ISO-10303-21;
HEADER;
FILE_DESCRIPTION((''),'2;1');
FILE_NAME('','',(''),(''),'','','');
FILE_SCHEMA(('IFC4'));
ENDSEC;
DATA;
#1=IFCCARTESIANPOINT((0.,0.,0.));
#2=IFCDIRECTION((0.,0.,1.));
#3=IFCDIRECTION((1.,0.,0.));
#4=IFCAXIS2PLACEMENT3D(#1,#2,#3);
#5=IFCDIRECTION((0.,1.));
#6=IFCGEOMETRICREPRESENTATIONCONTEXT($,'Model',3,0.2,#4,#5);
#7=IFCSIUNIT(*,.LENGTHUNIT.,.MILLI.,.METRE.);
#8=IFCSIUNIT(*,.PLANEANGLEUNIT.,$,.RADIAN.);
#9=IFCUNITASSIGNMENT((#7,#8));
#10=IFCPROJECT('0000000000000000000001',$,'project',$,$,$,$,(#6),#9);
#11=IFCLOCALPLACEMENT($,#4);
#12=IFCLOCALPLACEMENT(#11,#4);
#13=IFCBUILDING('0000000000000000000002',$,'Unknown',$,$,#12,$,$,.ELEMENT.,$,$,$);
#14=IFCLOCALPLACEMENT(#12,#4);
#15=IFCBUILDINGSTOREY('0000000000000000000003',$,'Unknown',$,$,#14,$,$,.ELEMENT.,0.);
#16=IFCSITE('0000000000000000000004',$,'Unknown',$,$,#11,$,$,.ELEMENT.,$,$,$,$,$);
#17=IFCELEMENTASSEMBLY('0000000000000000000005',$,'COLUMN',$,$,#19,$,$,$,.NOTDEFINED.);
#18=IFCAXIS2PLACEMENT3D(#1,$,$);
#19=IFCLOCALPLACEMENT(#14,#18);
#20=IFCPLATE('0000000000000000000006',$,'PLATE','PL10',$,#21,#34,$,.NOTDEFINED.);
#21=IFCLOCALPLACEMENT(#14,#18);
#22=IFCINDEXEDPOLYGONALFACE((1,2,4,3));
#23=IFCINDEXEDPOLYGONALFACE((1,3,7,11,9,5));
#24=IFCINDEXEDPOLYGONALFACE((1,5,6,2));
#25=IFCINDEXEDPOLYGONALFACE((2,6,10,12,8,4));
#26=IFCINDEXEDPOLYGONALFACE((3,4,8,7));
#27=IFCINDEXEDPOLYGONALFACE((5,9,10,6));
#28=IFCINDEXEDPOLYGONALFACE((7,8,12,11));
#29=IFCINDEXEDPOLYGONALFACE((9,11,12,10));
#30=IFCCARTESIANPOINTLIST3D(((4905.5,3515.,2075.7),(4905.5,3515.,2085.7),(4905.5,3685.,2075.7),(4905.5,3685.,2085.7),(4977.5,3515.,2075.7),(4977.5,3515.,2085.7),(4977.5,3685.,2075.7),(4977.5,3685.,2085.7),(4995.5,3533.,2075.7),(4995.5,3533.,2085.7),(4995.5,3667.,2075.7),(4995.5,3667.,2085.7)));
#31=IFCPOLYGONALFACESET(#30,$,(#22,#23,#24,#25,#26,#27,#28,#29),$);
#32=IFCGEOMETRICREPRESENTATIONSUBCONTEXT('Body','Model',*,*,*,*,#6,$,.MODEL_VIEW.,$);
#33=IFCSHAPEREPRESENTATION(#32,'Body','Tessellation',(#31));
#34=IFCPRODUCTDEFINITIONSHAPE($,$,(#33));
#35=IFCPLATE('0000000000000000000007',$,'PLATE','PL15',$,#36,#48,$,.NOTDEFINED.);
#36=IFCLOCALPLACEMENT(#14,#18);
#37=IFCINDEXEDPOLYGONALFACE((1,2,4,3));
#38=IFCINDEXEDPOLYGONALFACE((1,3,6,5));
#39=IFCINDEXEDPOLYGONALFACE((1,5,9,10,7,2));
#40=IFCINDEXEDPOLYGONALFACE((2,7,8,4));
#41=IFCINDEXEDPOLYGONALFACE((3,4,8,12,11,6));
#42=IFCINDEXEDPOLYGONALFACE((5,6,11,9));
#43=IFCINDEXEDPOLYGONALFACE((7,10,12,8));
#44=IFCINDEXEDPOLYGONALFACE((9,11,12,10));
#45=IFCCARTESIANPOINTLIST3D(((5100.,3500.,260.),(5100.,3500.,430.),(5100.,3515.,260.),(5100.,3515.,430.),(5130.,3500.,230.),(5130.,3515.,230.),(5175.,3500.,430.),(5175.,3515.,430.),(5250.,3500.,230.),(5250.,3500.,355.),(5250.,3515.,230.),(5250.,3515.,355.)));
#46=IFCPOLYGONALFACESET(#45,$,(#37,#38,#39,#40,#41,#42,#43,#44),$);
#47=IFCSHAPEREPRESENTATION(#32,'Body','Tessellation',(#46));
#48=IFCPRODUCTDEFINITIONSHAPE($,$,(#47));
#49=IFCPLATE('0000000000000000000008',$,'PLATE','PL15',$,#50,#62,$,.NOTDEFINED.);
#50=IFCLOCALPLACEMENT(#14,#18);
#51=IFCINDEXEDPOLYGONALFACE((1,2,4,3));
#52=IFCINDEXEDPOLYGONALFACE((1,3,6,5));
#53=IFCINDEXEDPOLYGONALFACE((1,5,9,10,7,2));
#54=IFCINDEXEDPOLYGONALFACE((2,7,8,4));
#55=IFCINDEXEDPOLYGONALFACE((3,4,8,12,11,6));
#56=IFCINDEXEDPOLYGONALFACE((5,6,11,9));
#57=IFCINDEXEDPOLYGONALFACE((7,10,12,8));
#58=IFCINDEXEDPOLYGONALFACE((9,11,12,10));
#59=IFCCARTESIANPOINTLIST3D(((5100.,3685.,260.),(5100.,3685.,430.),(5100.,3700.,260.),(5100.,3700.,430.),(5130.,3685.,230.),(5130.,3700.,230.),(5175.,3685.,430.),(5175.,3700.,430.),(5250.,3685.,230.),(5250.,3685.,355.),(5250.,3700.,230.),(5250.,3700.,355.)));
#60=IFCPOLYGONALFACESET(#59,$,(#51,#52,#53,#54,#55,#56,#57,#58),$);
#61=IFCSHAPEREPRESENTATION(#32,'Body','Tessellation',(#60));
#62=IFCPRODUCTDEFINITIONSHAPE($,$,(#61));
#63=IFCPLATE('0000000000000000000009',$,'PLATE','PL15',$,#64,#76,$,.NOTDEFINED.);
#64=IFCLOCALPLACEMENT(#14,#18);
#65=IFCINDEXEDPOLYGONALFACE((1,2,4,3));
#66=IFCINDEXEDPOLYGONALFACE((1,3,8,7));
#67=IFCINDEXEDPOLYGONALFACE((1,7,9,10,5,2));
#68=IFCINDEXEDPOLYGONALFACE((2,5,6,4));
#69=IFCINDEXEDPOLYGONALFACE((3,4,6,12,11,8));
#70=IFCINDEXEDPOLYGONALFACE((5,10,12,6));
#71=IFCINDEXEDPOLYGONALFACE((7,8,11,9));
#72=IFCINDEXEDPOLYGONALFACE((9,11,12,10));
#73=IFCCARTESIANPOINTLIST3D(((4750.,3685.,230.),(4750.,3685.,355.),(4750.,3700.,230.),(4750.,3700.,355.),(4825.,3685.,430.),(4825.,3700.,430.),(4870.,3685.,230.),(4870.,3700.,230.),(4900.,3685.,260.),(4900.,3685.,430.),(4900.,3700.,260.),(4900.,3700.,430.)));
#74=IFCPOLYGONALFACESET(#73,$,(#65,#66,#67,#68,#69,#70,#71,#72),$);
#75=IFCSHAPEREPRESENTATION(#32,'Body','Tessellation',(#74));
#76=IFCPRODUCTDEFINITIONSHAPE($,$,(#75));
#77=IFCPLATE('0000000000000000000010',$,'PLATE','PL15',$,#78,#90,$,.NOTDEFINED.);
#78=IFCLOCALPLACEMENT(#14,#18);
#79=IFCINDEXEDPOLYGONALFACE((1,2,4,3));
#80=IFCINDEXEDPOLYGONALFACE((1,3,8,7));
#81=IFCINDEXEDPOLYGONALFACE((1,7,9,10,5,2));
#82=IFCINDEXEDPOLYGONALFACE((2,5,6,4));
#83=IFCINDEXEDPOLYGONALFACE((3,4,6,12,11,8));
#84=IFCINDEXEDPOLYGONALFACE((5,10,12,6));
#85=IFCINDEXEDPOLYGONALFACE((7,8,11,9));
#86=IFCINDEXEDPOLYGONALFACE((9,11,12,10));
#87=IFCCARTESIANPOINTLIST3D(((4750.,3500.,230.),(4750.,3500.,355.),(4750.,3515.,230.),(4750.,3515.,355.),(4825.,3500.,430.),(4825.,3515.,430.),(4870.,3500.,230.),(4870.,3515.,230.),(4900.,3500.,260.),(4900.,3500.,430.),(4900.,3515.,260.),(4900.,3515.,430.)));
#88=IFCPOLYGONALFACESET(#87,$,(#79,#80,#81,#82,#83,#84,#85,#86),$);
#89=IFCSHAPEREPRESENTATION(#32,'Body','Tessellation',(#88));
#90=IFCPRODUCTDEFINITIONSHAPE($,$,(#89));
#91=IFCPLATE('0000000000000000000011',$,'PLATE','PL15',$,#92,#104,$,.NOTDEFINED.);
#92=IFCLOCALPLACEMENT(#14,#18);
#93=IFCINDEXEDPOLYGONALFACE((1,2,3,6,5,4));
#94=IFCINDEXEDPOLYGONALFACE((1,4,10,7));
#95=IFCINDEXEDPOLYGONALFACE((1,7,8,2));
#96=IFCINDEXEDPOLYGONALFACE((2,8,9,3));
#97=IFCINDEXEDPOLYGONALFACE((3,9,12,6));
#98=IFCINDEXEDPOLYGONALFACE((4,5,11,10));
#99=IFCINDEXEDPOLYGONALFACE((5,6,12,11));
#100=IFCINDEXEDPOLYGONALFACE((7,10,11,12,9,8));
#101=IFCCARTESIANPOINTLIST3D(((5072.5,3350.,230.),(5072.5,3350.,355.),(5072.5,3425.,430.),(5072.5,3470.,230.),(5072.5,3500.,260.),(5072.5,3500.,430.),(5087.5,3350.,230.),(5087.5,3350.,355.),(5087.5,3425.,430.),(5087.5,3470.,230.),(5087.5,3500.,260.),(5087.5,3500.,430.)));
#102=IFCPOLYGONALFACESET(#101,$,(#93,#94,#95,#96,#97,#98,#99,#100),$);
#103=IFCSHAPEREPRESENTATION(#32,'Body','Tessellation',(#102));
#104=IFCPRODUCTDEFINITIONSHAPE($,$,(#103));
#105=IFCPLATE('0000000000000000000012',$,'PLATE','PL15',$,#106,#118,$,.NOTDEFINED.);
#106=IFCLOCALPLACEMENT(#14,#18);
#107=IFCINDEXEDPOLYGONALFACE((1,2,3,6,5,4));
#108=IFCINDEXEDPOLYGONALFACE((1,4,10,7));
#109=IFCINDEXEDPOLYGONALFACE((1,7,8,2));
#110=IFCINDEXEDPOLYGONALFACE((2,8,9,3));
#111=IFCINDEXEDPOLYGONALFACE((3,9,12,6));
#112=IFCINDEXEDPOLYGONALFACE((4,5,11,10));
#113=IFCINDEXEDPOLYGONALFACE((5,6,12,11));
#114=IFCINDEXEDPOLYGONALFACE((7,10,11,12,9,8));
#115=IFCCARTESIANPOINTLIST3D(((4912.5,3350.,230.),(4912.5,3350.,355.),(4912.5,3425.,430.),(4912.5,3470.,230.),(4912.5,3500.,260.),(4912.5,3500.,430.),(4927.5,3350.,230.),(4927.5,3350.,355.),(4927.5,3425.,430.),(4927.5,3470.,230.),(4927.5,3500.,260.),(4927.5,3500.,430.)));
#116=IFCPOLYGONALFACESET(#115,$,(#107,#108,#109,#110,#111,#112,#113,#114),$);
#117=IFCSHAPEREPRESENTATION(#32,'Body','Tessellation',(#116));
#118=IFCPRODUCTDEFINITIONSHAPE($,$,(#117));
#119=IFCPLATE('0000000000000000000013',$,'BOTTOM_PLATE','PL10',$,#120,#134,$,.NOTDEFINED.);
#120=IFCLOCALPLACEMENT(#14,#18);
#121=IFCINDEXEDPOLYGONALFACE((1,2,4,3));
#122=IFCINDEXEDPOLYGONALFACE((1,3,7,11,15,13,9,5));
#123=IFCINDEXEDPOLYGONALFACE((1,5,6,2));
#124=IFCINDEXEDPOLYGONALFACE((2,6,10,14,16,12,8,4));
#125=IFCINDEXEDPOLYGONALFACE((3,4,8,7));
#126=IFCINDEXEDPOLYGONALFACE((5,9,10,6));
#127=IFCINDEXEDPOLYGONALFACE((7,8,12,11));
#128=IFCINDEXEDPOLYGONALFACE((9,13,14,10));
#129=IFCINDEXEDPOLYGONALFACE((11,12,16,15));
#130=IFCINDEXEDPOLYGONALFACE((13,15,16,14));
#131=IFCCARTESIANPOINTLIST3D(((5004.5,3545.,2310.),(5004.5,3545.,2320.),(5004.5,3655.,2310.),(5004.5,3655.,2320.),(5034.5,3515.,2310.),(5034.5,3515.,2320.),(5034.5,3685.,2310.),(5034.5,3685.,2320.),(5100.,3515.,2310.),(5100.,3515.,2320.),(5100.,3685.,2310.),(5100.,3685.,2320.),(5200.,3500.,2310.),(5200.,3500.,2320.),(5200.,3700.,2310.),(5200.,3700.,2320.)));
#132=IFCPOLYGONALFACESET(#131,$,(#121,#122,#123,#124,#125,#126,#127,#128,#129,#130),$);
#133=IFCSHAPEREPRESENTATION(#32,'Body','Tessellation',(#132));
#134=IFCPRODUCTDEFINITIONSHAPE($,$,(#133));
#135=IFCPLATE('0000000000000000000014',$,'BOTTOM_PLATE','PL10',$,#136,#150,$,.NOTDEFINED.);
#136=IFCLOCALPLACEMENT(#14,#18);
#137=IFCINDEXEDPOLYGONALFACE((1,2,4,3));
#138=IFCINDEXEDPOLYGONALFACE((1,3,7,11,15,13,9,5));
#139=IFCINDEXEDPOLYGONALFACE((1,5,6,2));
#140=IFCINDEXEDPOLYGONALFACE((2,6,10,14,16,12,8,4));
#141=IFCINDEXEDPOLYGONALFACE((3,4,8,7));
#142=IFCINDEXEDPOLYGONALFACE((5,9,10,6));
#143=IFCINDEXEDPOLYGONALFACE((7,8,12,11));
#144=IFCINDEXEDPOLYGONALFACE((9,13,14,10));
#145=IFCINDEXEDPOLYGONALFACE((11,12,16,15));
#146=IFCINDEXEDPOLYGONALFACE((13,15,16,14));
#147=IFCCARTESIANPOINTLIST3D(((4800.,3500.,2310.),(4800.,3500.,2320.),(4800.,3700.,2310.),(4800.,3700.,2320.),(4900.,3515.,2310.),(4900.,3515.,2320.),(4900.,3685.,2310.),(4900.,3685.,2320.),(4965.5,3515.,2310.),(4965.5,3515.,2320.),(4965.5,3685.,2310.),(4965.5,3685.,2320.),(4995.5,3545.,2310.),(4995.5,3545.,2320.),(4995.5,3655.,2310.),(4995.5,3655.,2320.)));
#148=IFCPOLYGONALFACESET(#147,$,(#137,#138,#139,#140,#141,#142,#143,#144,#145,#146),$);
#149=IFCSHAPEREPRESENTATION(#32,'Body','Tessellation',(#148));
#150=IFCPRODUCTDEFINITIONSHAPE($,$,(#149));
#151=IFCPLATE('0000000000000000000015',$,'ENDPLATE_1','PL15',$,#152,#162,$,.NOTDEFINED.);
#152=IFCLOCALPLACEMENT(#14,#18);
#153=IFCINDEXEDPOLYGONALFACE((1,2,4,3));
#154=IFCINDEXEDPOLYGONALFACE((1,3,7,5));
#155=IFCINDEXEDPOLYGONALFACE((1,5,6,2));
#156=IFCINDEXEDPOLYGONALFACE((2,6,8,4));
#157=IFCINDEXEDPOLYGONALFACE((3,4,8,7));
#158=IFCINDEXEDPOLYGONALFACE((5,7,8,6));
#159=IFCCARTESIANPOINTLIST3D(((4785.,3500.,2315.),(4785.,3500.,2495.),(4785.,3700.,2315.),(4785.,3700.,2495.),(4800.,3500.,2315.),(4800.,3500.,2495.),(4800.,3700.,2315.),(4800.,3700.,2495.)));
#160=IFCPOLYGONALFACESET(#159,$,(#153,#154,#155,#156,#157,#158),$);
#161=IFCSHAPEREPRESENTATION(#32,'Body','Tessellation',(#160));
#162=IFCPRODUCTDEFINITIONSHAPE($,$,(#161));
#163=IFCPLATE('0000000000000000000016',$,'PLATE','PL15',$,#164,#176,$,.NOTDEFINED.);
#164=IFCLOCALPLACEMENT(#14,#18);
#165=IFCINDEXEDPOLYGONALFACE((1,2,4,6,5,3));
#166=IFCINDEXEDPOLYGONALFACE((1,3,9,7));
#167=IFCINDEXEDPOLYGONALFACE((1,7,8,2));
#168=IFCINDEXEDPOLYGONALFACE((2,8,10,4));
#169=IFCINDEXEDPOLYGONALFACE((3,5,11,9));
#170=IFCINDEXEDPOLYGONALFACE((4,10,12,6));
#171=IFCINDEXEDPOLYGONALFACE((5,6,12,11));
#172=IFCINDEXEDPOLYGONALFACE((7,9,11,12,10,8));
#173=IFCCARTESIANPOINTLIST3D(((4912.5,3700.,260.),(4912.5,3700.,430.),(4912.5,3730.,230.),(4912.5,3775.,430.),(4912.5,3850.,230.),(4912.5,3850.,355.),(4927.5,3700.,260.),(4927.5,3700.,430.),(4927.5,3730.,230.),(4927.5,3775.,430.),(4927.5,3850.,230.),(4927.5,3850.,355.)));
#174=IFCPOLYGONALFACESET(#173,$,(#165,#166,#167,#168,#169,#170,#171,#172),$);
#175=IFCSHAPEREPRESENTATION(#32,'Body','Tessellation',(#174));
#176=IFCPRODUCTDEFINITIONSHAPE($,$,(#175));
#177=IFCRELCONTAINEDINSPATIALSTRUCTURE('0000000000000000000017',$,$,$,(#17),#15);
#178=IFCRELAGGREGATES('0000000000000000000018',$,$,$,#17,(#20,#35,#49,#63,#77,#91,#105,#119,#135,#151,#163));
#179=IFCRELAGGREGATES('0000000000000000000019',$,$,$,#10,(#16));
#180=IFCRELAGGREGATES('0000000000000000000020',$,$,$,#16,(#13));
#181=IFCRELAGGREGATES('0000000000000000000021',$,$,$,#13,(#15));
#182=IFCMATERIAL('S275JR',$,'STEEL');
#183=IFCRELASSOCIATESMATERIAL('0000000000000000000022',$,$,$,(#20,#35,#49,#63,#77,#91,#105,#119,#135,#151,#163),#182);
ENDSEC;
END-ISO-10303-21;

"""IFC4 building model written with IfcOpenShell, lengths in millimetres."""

from ifc_helpers import new_model, si_unit, direction, frame, origin_with_axes, place, context, subcontext, project, spatial, line, indexed_curve, outline, extrude, material, element, aggregate, save


model = new_model("IFC4")

# Units and contexts
model_context = context("Model", 3, precision=0.2, world=origin_with_axes(), true_north=direction((0.0, 1.0)))
body_context = subcontext(model_context, "Body", "Model", "MODEL_VIEW")
ifc_project = project(units=[si_unit("LENGTHUNIT", "METRE", prefix="MILLI"), si_unit("PLANEANGLEUNIT", "RADIAN")], contexts=[model_context])

# Site, building, storey
site_placement = place(None, origin_with_axes())
site = spatial("IfcSite", under=ifc_project, at=site_placement, Name="Unknown", CompositionType="ELEMENT")
building_placement = place(site_placement, origin_with_axes())
building = spatial("IfcBuilding", under=site, at=building_placement, Name="Unknown", CompositionType="ELEMENT")
storey_placement = place(building_placement, origin_with_axes())
storey = spatial("IfcBuildingStorey", under=building, at=storey_placement, Name="Unknown", CompositionType="ELEMENT", Elevation=0.0)

# Element assembly
ifc_material_1 = material(Name="S275JR", Category="STEEL")
assembly_1_placement = place(storey_placement, frame((5000.0, 3600.0, 200.0), z_axis=(-1.0, 0.0, 0.0), x_axis=(0.0, 0.0, 1.0)))
assembly_1 = element("IfcElementAssembly", 1, at=assembly_1_placement, inside=storey, Name="COLUMN", PredefinedType="NOTDEFINED")

# Plates
plate_1_placement = place(assembly_1_placement, frame((1880.7, -85.0, 94.5), z_axis=(1.0, 0.0, 0.0), x_axis=(0.0, -0.000002, -1.0)))
plate_1 = element("IfcPlate", 2, at=plate_1_placement, material=ifc_material_1, Name="PLATE", Description="PL10", PredefinedType="NOTDEFINED", context=body_context, shape_type="SolidModel", body=[
    extrude(outline(indexed_curve([(0.0, 0.0), (72.0, 0.0), (90.0, 18.0), (90.0, 152.0), (72.0, 170.0), (0.0, 170.0)], segments=[line(1, 2, 3, 4, 5, 6, 1)])), frame((0.0, 0.0, 5.0), z_axis=(0.0, 0.0, 1.0), x_axis=(1.0, 0.0, 0.0)), (0.0, -0.000002, -1.0), 10.0),
])
plate_2_placement = place(assembly_1_placement, frame((60.0, -92.5, -100.0), z_axis=(-0.000002, -1.0, 0.0), x_axis=(-0.707107, 0.0, -0.707107)))
plate_2 = element("IfcPlate", 3, at=plate_2_placement, material=ifc_material_1, Name="PLATE", Description="PL15", PredefinedType="NOTDEFINED", context=body_context, shape_type="SolidModel", body=[
    extrude(outline(indexed_curve([(0.0, 0.0), (42.4, 0.0), (127.3, 84.9), (38.9, 173.2), (-67.2, 173.2), (-120.2, 120.2)], segments=[line(1, 2, 3, 4, 5, 6, 1)])), frame((0.0, 0.0, 7.5), z_axis=(0.0, 0.0, 1.0), x_axis=(1.0, 0.0, 0.0)), (0.0, -0.000002, -1.0), 15.0),
])
plate_3_placement = place(assembly_1_placement, frame((60.0, 92.5, -100.0), z_axis=(-0.000002, -1.0, 0.0), x_axis=(-0.707107, 0.0, -0.707107)))
plate_3 = element("IfcPlate", 4, at=plate_3_placement, material=ifc_material_1, Name="PLATE", Description="PL15", PredefinedType="NOTDEFINED", context=body_context, shape_type="SolidModel", body=[
    extrude(outline(indexed_curve([(0.0, 0.0), (42.4, 0.0), (127.3, 84.9), (38.9, 173.2), (-67.2, 173.2), (-120.2, 120.2)], segments=[line(1, 2, 3, 4, 5, 6, 1)])), frame((0.0, 0.0, 7.5), z_axis=(0.0, 0.0, 1.0), x_axis=(1.0, 0.0, 0.0)), (0.0, -0.000002, -1.0), 15.0),
])
plate_4_placement = place(assembly_1_placement, frame((60.0, 92.5, 100.0), z_axis=(0.0, 1.0, 0.0), x_axis=(-0.707107, 0.0, 0.707107)))
plate_4 = element("IfcPlate", 5, at=plate_4_placement, material=ifc_material_1, Name="PLATE", Description="PL15", PredefinedType="NOTDEFINED", context=body_context, shape_type="SolidModel", body=[
    extrude(outline(indexed_curve([(0.0, 0.0), (42.4, 0.0), (127.3, 84.9), (38.9, 173.2), (-67.2, 173.2), (-120.2, 120.2)], segments=[line(1, 2, 3, 4, 5, 6, 1)])), frame((0.0, 0.0, 7.5), z_axis=(0.0, 0.0, 1.0), x_axis=(1.0, 0.0, 0.0)), (0.0, -0.000002, -1.0), 15.0),
])
plate_5_placement = place(assembly_1_placement, frame((60.0, -92.5, 100.0), z_axis=(0.0, 1.0, 0.0), x_axis=(-0.707107, 0.0, 0.707107)))
plate_5 = element("IfcPlate", 6, at=plate_5_placement, material=ifc_material_1, Name="PLATE", Description="PL15", PredefinedType="NOTDEFINED", context=body_context, shape_type="SolidModel", body=[
    extrude(outline(indexed_curve([(0.0, 0.0), (42.4, 0.0), (127.3, 84.9), (38.9, 173.2), (-67.2, 173.2), (-120.2, 120.2)], segments=[line(1, 2, 3, 4, 5, 6, 1)])), frame((0.0, 0.0, 7.5), z_axis=(0.0, 0.0, 1.0), x_axis=(1.0, 0.0, 0.0)), (0.0, -0.000002, -1.0), 15.0),
])
plate_6_placement = place(assembly_1_placement, frame((60.0, -100.0, -80.0), z_axis=(0.0, 0.0, 1.0), x_axis=(-0.707116, -0.707097, 0.0)))
plate_6 = element("IfcPlate", 7, at=plate_6_placement, material=ifc_material_1, Name="PLATE", Description="PL15", PredefinedType="NOTDEFINED", context=body_context, shape_type="SolidModel", body=[
    extrude(outline(indexed_curve([(0.0, 0.0), (42.4, 0.0), (127.3, 84.9), (38.9, 173.2), (-67.2, 173.2), (-120.2, 120.2)], segments=[line(1, 2, 3, 4, 5, 6, 1)])), frame((0.0, 0.0, 7.5), z_axis=(0.0, 0.0, 1.0), x_axis=(1.0, 0.0, 0.0)), (0.0, -0.000002, -1.0), 15.0),
])
plate_7_placement = place(assembly_1_placement, frame((60.0, -100.0, 80.0), z_axis=(0.0, 0.0, 1.0), x_axis=(-0.707116, -0.707097, 0.0)))
plate_7 = element("IfcPlate", 8, at=plate_7_placement, material=ifc_material_1, Name="PLATE", Description="PL15", PredefinedType="NOTDEFINED", context=body_context, shape_type="SolidModel", body=[
    extrude(outline(indexed_curve([(0.0, 0.0), (42.4, 0.0), (127.3, 84.9), (38.9, 173.2), (-67.2, 173.2), (-120.2, 120.2)], segments=[line(1, 2, 3, 4, 5, 6, 1)])), frame((0.0, 0.0, 7.5), z_axis=(0.0, 0.0, 1.0), x_axis=(1.0, 0.0, 0.0)), (0.0, -0.000002, -1.0), 15.0),
])
plate_8_placement = place(assembly_1_placement, frame((2115.0, 85.0, -4.5), z_axis=(1.0, 0.0, 0.0), x_axis=(-0.000002, -1.0, 0.0)))
plate_8 = element("IfcPlate", 9, at=plate_8_placement, material=ifc_material_1, Name="BOTTOM_PLATE", Description="PL10", PredefinedType="NOTDEFINED", context=body_context, shape_type="SolidModel", body=[
    extrude(outline(indexed_curve([(0.0, 30.0), (30.0, 0.0), (140.0, 0.0), (170.0, 30.0), (170.0, 95.5), (185.0, 195.5), (-15.0, 195.5), (0.0, 95.5)], segments=[line(1, 2, 3, 4, 5, 6, 7, 8, 1)])), frame((0.0, 0.0, 5.0), z_axis=(0.0, 0.0, 1.0), x_axis=(1.0, 0.0, 0.0)), (0.0, -0.000002, -1.0), 10.0),
])
plate_9_placement = place(assembly_1_placement, frame((2115.0, -85.0, 4.5), z_axis=(1.0, 0.0, 0.0), x_axis=(0.0, 1.0, 0.0)))
plate_9 = element("IfcPlate", 10, at=plate_9_placement, material=ifc_material_1, Name="BOTTOM_PLATE", Description="PL10", PredefinedType="NOTDEFINED", context=body_context, shape_type="SolidModel", body=[
    extrude(outline(indexed_curve([(0.0, 30.0), (30.0, 0.0), (140.0, 0.0), (170.0, 30.0), (170.0, 95.5), (185.0, 195.5), (-15.0, 195.5), (0.0, 95.5)], segments=[line(1, 2, 3, 4, 5, 6, 7, 8, 1)])), frame((0.0, 0.0, 5.0), z_axis=(0.0, 0.0, 1.0), x_axis=(1.0, 0.0, 0.0)), (0.0, -0.000002, -1.0), 10.0),
])
plate_10_placement = place(assembly_1_placement, frame((2115.0, -100.0, 207.5), z_axis=(0.0, 0.0, 1.0), x_axis=(1.0, 0.0, 0.0)))
plate_10 = element("IfcPlate", 11, at=plate_10_placement, material=ifc_material_1, Name="ENDPLATE_1", Description="PL15", PredefinedType="NOTDEFINED", context=body_context, shape_type="SolidModel", body=[
    extrude(outline(indexed_curve([(0.0, 0.0), (180.0, 0.0), (180.0, 200.0), (0.0, 200.0)], segments=[line(1, 2, 3, 4, 1)])), frame((0.0, 0.0, 7.5), z_axis=(0.0, 0.0, 1.0), x_axis=(1.0, 0.0, 0.0)), (0.0, -0.000002, -1.0), 15.0),
])
plate_11_placement = place(assembly_1_placement, frame((60.0, 100.0, 80.0), z_axis=(0.0, -0.000002, -1.0), x_axis=(-0.707113, 0.707101, 0.0)))
plate_11 = element("IfcPlate", 12, at=plate_11_placement, material=ifc_material_1, Name="PLATE", Description="PL15", PredefinedType="NOTDEFINED", context=body_context, shape_type="SolidModel", body=[
    extrude(outline(indexed_curve([(0.0, 0.0), (42.4, 0.0), (127.3, 84.9), (38.9, 173.2), (-67.2, 173.2), (-120.2, 120.2)], segments=[line(1, 2, 3, 4, 5, 6, 1)])), frame((0.0, 0.0, 7.5), z_axis=(0.0, 0.0, 1.0), x_axis=(1.0, 0.0, 0.0)), (0.0, -0.000002, -1.0), 15.0),
])

aggregate(assembly_1, [plate_1, plate_2, plate_3, plate_4, plate_5, plate_6, plate_7, plate_8, plate_9, plate_10, plate_11])

save(model, "model.ifc")
